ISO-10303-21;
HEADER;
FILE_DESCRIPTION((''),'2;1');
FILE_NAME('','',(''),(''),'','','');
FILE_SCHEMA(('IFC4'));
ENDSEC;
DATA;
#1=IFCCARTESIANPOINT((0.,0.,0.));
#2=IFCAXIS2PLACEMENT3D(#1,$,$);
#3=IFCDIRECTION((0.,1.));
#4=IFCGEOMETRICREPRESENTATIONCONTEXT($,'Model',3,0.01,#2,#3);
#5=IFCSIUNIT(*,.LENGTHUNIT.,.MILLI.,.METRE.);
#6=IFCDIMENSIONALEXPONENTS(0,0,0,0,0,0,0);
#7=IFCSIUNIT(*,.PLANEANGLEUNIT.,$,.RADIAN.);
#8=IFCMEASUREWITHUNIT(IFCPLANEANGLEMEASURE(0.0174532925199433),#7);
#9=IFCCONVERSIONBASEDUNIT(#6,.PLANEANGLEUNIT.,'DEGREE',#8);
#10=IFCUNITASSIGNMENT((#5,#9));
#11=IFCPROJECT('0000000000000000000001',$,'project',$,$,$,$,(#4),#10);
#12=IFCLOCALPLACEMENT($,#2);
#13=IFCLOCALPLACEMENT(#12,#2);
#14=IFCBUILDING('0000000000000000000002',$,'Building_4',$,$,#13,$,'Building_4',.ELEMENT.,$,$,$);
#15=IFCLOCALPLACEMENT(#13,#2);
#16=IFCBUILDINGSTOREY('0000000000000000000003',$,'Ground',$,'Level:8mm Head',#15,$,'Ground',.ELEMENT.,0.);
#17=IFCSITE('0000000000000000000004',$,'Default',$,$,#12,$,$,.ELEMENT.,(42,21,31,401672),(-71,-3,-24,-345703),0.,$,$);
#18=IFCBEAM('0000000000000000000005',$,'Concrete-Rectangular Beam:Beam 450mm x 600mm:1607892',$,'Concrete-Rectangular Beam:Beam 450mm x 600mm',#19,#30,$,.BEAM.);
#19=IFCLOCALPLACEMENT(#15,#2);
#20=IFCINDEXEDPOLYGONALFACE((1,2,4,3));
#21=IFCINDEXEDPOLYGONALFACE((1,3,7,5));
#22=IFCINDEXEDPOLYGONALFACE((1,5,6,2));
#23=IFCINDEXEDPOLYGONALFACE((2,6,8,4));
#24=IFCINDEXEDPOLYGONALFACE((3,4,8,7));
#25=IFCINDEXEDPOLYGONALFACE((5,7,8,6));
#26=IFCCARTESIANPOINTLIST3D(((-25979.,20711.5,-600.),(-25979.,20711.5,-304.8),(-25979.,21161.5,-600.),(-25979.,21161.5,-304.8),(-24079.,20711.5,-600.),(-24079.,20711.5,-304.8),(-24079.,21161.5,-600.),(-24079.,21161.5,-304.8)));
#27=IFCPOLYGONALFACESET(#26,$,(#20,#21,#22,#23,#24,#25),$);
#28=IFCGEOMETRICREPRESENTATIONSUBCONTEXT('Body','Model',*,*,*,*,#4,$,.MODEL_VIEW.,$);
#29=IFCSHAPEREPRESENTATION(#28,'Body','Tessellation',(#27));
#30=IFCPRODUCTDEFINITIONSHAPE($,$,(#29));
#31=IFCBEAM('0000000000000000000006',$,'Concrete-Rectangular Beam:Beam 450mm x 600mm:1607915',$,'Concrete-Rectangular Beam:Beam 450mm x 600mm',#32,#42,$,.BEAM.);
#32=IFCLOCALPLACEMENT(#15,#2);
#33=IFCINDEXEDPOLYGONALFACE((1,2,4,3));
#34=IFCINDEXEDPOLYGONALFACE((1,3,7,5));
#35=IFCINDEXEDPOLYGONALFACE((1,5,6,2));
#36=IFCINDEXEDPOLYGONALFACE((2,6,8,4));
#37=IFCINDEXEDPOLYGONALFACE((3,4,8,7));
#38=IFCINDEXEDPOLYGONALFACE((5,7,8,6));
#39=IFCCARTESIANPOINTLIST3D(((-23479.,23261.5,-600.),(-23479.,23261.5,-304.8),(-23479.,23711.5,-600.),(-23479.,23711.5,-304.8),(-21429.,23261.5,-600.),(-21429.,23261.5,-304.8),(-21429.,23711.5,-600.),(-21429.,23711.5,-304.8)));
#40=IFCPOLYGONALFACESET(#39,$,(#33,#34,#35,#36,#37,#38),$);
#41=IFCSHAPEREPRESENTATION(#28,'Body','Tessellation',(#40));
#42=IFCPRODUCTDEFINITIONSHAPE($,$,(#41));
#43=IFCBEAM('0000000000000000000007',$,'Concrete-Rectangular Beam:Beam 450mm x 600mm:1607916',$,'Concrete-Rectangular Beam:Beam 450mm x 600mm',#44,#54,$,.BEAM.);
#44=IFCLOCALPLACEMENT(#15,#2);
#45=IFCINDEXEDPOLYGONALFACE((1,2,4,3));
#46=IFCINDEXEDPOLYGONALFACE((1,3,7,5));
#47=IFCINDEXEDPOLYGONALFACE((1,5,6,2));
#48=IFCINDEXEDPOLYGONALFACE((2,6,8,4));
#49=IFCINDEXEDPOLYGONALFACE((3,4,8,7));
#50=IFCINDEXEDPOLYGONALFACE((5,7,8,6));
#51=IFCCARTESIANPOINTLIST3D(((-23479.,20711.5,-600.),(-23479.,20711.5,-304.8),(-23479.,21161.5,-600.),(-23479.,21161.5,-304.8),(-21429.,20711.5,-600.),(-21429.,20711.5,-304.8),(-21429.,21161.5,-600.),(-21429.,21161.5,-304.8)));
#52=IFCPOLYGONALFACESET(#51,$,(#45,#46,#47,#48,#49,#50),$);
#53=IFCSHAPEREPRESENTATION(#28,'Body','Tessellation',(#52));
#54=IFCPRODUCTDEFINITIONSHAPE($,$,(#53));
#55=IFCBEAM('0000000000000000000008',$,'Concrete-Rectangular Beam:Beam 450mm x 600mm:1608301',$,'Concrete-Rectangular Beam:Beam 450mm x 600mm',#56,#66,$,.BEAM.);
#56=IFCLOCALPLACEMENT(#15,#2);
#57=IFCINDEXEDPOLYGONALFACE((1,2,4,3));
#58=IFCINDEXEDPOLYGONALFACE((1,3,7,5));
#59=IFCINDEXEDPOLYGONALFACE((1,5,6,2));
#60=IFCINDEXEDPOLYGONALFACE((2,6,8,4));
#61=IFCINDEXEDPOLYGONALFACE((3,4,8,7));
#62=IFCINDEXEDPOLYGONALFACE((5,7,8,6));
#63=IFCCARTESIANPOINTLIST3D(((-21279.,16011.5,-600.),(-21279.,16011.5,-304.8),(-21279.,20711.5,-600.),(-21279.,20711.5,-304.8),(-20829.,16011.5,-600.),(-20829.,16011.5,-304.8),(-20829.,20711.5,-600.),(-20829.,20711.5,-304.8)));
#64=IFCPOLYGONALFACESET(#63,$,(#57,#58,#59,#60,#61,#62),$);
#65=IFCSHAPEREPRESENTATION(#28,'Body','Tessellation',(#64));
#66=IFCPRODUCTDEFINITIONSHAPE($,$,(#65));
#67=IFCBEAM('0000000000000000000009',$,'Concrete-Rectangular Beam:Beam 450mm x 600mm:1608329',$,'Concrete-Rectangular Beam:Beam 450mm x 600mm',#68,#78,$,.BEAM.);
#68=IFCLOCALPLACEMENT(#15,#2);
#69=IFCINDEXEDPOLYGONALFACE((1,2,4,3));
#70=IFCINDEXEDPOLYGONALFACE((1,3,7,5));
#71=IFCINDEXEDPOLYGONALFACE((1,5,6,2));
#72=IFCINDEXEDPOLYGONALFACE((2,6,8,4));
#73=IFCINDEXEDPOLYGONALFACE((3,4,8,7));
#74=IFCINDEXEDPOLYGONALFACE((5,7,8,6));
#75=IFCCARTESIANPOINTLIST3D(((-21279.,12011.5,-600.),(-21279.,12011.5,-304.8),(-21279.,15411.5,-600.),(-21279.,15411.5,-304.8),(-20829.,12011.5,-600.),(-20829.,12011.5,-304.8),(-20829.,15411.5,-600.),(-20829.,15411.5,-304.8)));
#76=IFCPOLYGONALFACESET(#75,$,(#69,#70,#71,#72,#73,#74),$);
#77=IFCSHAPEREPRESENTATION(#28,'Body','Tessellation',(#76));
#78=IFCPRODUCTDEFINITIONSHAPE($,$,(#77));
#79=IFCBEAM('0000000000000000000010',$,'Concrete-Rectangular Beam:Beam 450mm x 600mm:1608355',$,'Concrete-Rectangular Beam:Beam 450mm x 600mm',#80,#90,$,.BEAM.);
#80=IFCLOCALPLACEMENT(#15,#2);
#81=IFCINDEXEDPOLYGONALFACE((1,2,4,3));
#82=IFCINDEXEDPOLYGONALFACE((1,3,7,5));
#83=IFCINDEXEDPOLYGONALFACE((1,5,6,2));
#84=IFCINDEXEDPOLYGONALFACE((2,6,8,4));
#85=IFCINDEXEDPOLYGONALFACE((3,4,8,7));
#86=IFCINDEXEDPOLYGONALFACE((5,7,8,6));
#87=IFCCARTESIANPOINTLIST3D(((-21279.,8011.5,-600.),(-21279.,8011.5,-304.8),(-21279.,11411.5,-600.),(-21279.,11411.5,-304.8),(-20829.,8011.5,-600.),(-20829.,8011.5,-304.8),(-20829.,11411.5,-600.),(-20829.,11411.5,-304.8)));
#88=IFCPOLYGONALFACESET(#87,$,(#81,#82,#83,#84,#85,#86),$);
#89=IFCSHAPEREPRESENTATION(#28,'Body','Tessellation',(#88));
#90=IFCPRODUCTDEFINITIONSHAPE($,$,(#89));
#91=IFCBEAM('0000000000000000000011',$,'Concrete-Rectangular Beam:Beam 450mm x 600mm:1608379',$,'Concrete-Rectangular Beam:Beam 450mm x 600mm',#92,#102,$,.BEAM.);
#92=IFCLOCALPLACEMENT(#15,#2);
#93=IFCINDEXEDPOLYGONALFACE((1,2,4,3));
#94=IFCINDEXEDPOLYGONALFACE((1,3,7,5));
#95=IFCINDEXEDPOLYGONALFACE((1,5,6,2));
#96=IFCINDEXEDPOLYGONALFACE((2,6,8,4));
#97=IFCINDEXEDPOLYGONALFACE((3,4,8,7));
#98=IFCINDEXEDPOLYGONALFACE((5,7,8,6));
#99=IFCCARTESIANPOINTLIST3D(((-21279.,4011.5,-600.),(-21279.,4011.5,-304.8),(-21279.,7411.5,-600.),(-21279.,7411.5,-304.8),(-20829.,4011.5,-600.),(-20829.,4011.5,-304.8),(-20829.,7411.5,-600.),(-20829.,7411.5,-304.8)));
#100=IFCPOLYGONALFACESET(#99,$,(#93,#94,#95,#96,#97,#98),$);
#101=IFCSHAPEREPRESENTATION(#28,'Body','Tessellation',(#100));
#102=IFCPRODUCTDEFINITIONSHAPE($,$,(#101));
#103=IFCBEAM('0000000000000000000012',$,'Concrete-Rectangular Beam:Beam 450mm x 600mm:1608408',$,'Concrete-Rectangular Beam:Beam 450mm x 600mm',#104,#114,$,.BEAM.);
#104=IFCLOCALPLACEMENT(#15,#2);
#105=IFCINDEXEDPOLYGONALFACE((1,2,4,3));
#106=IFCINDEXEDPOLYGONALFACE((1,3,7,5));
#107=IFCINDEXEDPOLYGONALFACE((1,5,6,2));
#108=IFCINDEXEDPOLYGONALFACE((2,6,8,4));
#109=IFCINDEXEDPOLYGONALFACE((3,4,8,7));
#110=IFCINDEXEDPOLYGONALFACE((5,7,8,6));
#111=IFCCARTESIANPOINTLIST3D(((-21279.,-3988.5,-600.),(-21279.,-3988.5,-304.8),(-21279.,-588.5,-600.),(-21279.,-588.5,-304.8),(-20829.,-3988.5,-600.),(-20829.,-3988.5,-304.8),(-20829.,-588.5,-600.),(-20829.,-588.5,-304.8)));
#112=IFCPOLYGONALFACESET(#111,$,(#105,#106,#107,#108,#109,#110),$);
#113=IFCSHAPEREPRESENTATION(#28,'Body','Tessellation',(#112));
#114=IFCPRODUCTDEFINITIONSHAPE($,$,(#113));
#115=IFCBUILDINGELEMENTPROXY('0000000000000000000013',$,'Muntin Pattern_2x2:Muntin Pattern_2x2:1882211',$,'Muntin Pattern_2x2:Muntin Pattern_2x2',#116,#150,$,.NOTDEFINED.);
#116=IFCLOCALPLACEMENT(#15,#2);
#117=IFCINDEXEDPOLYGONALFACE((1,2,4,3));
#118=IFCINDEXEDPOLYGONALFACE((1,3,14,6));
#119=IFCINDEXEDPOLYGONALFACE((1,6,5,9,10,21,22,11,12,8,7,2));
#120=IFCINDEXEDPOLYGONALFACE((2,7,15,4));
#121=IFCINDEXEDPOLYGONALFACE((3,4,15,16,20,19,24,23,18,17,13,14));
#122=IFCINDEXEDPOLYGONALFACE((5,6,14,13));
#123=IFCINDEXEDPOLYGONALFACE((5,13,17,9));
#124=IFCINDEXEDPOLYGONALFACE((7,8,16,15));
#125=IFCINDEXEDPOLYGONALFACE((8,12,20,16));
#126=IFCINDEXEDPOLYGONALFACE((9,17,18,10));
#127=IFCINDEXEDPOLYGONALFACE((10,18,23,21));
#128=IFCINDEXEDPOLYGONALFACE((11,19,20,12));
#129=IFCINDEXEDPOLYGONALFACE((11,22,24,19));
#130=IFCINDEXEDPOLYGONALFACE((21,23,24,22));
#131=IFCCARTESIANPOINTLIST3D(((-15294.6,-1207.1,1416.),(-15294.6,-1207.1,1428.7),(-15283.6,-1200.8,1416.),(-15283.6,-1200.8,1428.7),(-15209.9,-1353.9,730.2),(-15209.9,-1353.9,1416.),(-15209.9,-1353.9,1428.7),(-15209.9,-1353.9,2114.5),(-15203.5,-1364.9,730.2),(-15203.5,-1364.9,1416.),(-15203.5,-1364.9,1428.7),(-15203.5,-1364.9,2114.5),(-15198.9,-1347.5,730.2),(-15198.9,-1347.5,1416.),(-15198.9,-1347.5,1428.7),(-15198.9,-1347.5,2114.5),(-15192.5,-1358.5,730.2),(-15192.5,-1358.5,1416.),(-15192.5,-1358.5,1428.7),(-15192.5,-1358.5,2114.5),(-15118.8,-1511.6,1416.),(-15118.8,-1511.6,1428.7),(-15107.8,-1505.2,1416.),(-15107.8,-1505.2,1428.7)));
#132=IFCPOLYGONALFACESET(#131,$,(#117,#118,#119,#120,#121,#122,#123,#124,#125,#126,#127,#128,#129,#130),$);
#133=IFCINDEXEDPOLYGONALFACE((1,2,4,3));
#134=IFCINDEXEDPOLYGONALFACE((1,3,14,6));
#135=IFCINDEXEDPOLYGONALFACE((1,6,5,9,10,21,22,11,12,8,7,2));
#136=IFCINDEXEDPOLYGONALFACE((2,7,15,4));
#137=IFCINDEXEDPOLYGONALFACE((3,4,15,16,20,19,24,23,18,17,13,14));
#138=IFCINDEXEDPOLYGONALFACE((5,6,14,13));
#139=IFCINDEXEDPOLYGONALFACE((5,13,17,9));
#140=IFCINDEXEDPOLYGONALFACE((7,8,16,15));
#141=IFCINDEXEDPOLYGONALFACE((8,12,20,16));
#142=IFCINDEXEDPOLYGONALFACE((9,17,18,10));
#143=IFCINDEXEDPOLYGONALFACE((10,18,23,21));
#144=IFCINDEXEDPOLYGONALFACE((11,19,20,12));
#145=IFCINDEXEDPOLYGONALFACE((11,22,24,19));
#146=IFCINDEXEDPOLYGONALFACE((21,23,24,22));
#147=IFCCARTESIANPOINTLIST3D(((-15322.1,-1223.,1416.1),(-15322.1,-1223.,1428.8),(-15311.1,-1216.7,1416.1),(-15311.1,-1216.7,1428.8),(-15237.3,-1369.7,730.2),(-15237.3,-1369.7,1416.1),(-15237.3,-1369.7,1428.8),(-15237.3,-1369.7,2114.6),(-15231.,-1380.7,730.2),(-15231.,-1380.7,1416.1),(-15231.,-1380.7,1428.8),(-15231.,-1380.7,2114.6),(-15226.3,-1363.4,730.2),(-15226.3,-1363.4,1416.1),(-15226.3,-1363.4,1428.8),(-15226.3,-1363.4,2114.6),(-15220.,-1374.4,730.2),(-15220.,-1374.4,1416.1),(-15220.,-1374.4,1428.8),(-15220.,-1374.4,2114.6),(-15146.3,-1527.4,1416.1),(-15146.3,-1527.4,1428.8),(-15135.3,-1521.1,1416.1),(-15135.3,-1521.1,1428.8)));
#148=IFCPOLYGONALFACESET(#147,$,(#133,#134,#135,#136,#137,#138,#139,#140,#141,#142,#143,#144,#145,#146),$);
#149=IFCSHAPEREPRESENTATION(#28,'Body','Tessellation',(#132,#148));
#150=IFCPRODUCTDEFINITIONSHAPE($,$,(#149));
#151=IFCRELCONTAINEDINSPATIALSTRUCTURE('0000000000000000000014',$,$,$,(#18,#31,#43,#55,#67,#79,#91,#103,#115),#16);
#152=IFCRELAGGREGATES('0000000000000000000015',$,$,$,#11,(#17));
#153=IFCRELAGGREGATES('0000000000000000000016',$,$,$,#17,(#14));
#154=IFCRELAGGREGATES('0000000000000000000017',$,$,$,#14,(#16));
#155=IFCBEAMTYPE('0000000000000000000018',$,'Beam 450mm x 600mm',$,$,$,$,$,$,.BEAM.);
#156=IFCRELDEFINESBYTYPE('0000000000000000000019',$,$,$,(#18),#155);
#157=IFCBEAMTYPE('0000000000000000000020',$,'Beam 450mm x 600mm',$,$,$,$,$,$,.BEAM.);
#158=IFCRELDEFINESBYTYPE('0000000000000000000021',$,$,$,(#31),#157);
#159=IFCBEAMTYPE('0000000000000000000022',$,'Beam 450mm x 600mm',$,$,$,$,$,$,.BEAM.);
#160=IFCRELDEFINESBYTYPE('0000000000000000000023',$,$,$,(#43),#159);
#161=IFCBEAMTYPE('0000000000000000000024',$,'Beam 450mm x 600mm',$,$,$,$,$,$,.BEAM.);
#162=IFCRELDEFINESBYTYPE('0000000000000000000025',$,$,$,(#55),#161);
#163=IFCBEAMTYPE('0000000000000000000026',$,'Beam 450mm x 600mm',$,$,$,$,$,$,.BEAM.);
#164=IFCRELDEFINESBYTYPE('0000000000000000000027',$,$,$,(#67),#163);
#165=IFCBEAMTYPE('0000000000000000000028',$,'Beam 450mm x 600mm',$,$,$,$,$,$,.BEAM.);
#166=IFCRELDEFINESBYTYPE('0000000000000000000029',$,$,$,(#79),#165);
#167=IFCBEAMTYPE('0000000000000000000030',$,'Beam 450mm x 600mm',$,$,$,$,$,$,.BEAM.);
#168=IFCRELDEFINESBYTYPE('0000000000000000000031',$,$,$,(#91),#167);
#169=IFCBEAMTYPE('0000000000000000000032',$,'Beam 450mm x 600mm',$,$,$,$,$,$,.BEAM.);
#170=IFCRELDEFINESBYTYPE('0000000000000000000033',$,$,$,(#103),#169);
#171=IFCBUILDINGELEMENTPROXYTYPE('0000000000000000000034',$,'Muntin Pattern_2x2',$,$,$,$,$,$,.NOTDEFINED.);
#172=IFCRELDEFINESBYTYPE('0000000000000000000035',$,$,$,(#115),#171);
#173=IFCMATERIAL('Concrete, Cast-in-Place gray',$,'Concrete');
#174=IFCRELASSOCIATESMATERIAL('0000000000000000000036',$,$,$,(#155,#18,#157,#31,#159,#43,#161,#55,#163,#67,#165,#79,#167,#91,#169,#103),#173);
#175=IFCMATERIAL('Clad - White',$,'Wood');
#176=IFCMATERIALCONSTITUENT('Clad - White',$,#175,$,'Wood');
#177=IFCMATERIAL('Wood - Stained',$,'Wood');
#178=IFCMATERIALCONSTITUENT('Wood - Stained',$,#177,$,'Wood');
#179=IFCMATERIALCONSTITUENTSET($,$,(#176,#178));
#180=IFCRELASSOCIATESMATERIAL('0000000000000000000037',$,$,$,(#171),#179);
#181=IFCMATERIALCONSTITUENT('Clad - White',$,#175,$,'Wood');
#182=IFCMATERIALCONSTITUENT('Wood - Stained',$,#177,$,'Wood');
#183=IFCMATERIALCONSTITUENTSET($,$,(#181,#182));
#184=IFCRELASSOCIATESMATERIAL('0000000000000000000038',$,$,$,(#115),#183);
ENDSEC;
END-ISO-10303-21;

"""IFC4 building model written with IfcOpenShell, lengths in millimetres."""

from ifc_helpers import new_model, entity, si_unit, converted_unit, direction, frame, origin, place, context, subcontext, project, spatial, indexed_curve, outline, extrude, source, transform, mapped, material, constituent, constituent_set, type_object, type_shapes, element, save


model = new_model("IFC4")

# Units and contexts
model_context = context("Model", 3, precision=0.01, world=origin(), true_north=direction((0.0, 1.0)))
body_context = subcontext(model_context, "Body", "Model", "MODEL_VIEW")
ifc_project = project(units=[si_unit("LENGTHUNIT", "METRE", prefix="MILLI"), converted_unit("PLANEANGLEUNIT", "DEGREE", entity("IfcPlaneAngleMeasure", 0.0174532925199433), si_unit("PLANEANGLEUNIT", "RADIAN"), dimensions=[0, 0, 0, 0, 0, 0, 0])], contexts=[model_context])

# Site, building, storey
site_placement = place(None, origin())
site = spatial("IfcSite", under=ifc_project, at=site_placement, Name="Default", CompositionType="ELEMENT", RefLatitude=(42, 21, 31, 401672), RefLongitude=(-71, -3, -24, -345703), RefElevation=0.0)
building_placement = place(site_placement, origin())
building = spatial("IfcBuilding", under=site, at=building_placement, Name="Building_4", LongName="Building_4", CompositionType="ELEMENT")
storey_placement = place(building_placement, origin())
storey = spatial("IfcBuildingStorey", under=building, at=storey_placement, Name="Ground", ObjectType="Level:8mm Head", LongName="Ground", CompositionType="ELEMENT", Elevation=0.0)

# Shared definitions
ifc_material_1 = material(Name="Concrete, Cast-in-Place gray", Category="Concrete")

# Beams
beam_type_1 = type_object("IfcBeamType", Name="Beam 450mm x 600mm", PredefinedType="BEAM", material=ifc_material_1)
shared_shape_1 = source(origin(), body_context, "Body", "SweptSolid", [
    extrude(outline(indexed_curve([(-147.6, -225.0), (147.6, -225.0), (147.6, 225.0), (-147.6, 225.0), (-147.6, -225.0)], self_intersect=False)), frame((-25979.0, 20936.5, -452.4), z_axis=(1.0, 0.0, 0.0), x_axis=(0.0, 0.0, -1.0)), (0.0, 0.0, 1.0), 1900.0),
])
type_shapes(beam_type_1, [shared_shape_1])
beam_1_placement = place(storey_placement, origin())
element("IfcBeam", 1, at=beam_1_placement, inside=storey, type_object=beam_type_1, material=ifc_material_1, Name="Concrete-Rectangular Beam:Beam 450mm x 600mm:1607892", ObjectType="Concrete-Rectangular Beam:Beam 450mm x 600mm", PredefinedType="BEAM", context=body_context, shape_type="MappedRepresentation", body=[
    mapped(shared_shape_1, transform((0.0, 0.0, 0.0), scale=1.0)),
])
beam_type_2 = type_object("IfcBeamType", Name="Beam 450mm x 600mm", PredefinedType="BEAM", material=ifc_material_1)
shared_shape_2 = source(origin(), body_context, "Body", "SweptSolid", [
    extrude(outline(indexed_curve([(-147.6, -225.0), (147.6, -225.0), (147.6, 225.0), (-147.6, 225.0), (-147.6, -225.0)], self_intersect=False)), frame((-23479.0, 23486.5, -452.4), z_axis=(1.0, 0.0, 0.0), x_axis=(0.0, 0.0, -1.0)), (0.0, 0.0, 1.0), 2050.0),
])
type_shapes(beam_type_2, [shared_shape_2])
beam_2_placement = place(storey_placement, origin())
element("IfcBeam", 2, at=beam_2_placement, inside=storey, type_object=beam_type_2, material=ifc_material_1, Name="Concrete-Rectangular Beam:Beam 450mm x 600mm:1607915", ObjectType="Concrete-Rectangular Beam:Beam 450mm x 600mm", PredefinedType="BEAM", context=body_context, shape_type="MappedRepresentation", body=[
    mapped(shared_shape_2, transform((0.0, 0.0, 0.0), scale=1.0)),
])
beam_type_3 = type_object("IfcBeamType", Name="Beam 450mm x 600mm", PredefinedType="BEAM", material=ifc_material_1)
shared_shape_3 = source(origin(), body_context, "Body", "SweptSolid", [
    extrude(outline(indexed_curve([(-147.6, -225.0), (147.6, -225.0), (147.6, 225.0), (-147.6, 225.0), (-147.6, -225.0)], self_intersect=False)), frame((-23479.0, 20936.5, -452.4), z_axis=(1.0, 0.0, 0.0), x_axis=(0.0, 0.0, -1.0)), (0.0, 0.0, 1.0), 2050.0),
])
type_shapes(beam_type_3, [shared_shape_3])
beam_3_placement = place(storey_placement, origin())
element("IfcBeam", 3, at=beam_3_placement, inside=storey, type_object=beam_type_3, material=ifc_material_1, Name="Concrete-Rectangular Beam:Beam 450mm x 600mm:1607916", ObjectType="Concrete-Rectangular Beam:Beam 450mm x 600mm", PredefinedType="BEAM", context=body_context, shape_type="MappedRepresentation", body=[
    mapped(shared_shape_3, transform((0.0, 0.0, 0.0), scale=1.0)),
])
beam_type_4 = type_object("IfcBeamType", Name="Beam 450mm x 600mm", PredefinedType="BEAM", material=ifc_material_1)
shared_shape_4 = source(origin(), body_context, "Body", "SweptSolid", [
    extrude(outline(indexed_curve([(-225.0, -147.6), (225.0, -147.6), (225.0, 147.6), (-225.0, 147.6), (-225.0, -147.6)], self_intersect=False)), frame((-21054.0, 16011.5, -452.4), z_axis=(0.0, 1.0, 0.0), x_axis=(-1.0, 0.0, 0.0)), (0.0, 0.0, 1.0), 4700.0),
])
type_shapes(beam_type_4, [shared_shape_4])
beam_4_placement = place(storey_placement, origin())
element("IfcBeam", 4, at=beam_4_placement, inside=storey, type_object=beam_type_4, material=ifc_material_1, Name="Concrete-Rectangular Beam:Beam 450mm x 600mm:1608301", ObjectType="Concrete-Rectangular Beam:Beam 450mm x 600mm", PredefinedType="BEAM", context=body_context, shape_type="MappedRepresentation", body=[
    mapped(shared_shape_4, transform((0.0, 0.0, 0.0), scale=1.0)),
])
beam_type_5 = type_object("IfcBeamType", Name="Beam 450mm x 600mm", PredefinedType="BEAM", material=ifc_material_1)
shared_shape_5 = source(origin(), body_context, "Body", "SweptSolid", [
    extrude(outline(indexed_curve([(-225.0, -147.6), (225.0, -147.6), (225.0, 147.6), (-225.0, 147.6), (-225.0, -147.6)], self_intersect=False)), frame((-21054.0, 12011.5, -452.4), z_axis=(0.0, 1.0, 0.0), x_axis=(-1.0, 0.0, 0.0)), (0.0, 0.0, 1.0), 3400.0),
])
type_shapes(beam_type_5, [shared_shape_5])
beam_5_placement = place(storey_placement, origin())
element("IfcBeam", 5, at=beam_5_placement, inside=storey, type_object=beam_type_5, material=ifc_material_1, Name="Concrete-Rectangular Beam:Beam 450mm x 600mm:1608329", ObjectType="Concrete-Rectangular Beam:Beam 450mm x 600mm", PredefinedType="BEAM", context=body_context, shape_type="MappedRepresentation", body=[
    mapped(shared_shape_5, transform((0.0, 0.0, 0.0), scale=1.0)),
])
beam_type_6 = type_object("IfcBeamType", Name="Beam 450mm x 600mm", PredefinedType="BEAM", material=ifc_material_1)
shared_shape_6 = source(origin(), body_context, "Body", "SweptSolid", [
    extrude(outline(indexed_curve([(-225.0, -147.6), (225.0, -147.6), (225.0, 147.6), (-225.0, 147.6), (-225.0, -147.6)], self_intersect=False)), frame((-21054.0, 8011.5, -452.4), z_axis=(0.0, 1.0, 0.0), x_axis=(-1.0, 0.0, 0.0)), (0.0, 0.0, 1.0), 3400.0),
])
type_shapes(beam_type_6, [shared_shape_6])
beam_6_placement = place(storey_placement, origin())
element("IfcBeam", 6, at=beam_6_placement, inside=storey, type_object=beam_type_6, material=ifc_material_1, Name="Concrete-Rectangular Beam:Beam 450mm x 600mm:1608355", ObjectType="Concrete-Rectangular Beam:Beam 450mm x 600mm", PredefinedType="BEAM", context=body_context, shape_type="MappedRepresentation", body=[
    mapped(shared_shape_6, transform((0.0, 0.0, 0.0), scale=1.0)),
])
beam_type_7 = type_object("IfcBeamType", Name="Beam 450mm x 600mm", PredefinedType="BEAM", material=ifc_material_1)
shared_shape_7 = source(origin(), body_context, "Body", "SweptSolid", [
    extrude(outline(indexed_curve([(-225.0, -147.6), (225.0, -147.6), (225.0, 147.6), (-225.0, 147.6), (-225.0, -147.6)], self_intersect=False)), frame((-21054.0, 4011.5, -452.4), z_axis=(0.0, 1.0, 0.0), x_axis=(-1.0, 0.0, 0.0)), (0.0, 0.0, 1.0), 3400.0),
])
type_shapes(beam_type_7, [shared_shape_7])
beam_7_placement = place(storey_placement, origin())
element("IfcBeam", 7, at=beam_7_placement, inside=storey, type_object=beam_type_7, material=ifc_material_1, Name="Concrete-Rectangular Beam:Beam 450mm x 600mm:1608379", ObjectType="Concrete-Rectangular Beam:Beam 450mm x 600mm", PredefinedType="BEAM", context=body_context, shape_type="MappedRepresentation", body=[
    mapped(shared_shape_7, transform((0.0, 0.0, 0.0), scale=1.0)),
])
beam_type_8 = type_object("IfcBeamType", Name="Beam 450mm x 600mm", PredefinedType="BEAM", material=ifc_material_1)
shared_shape_8 = source(origin(), body_context, "Body", "SweptSolid", [
    extrude(outline(indexed_curve([(-225.0, -147.6), (225.0, -147.6), (225.0, 147.6), (-225.0, 147.6), (-225.0, -147.6)], self_intersect=False)), frame((-21054.0, -588.5, -452.4), z_axis=(0.0, -1.0, 0.0), x_axis=(-1.0, 0.0, 0.0)), (0.0, 0.0, 1.0), 3400.0),
])
type_shapes(beam_type_8, [shared_shape_8])
beam_8_placement = place(storey_placement, origin())
element("IfcBeam", 8, at=beam_8_placement, inside=storey, type_object=beam_type_8, material=ifc_material_1, Name="Concrete-Rectangular Beam:Beam 450mm x 600mm:1608408", ObjectType="Concrete-Rectangular Beam:Beam 450mm x 600mm", PredefinedType="BEAM", context=body_context, shape_type="MappedRepresentation", body=[
    mapped(shared_shape_8, transform((0.0, 0.0, 0.0), scale=1.0)),
])

# Building element proxy
ifc_material_2 = material(Name="Clad - White", Category="Wood")
ifc_constituent_1 = constituent(ifc_material_2, Name="Clad - White", Category="Wood")
ifc_material_3 = material(Name="Wood - Stained", Category="Wood")
ifc_constituent_2 = constituent(ifc_material_3, Name="Wood - Stained", Category="Wood")
ifc_constituent_set_1 = constituent_set(constituents=[ifc_constituent_1, ifc_constituent_2])
ifc_constituent_3 = constituent(ifc_material_2, Name="Clad - White", Category="Wood")
ifc_constituent_4 = constituent(ifc_material_3, Name="Wood - Stained", Category="Wood")
ifc_constituent_set_2 = constituent_set(constituents=[ifc_constituent_3, ifc_constituent_4])
building_element_proxy_type_1 = type_object("IfcBuildingElementProxyType", Name="Muntin Pattern_2x2", PredefinedType="NOTDEFINED", material=ifc_constituent_set_2)
shared_shape_9 = source(origin(), body_context, "Body", "SweptSolid", [
    extrude(outline(indexed_curve([(6.4, -6.4), (692.1, -6.4), (692.1, 6.3), (6.4, 6.3), (6.4, 175.8), (-6.3, 175.8), (-6.3, 6.3), (-692.2, 6.3), (-692.2, -6.4), (-6.3, -6.4), (-6.3, -175.8), (6.4, -175.8), (6.4, -6.4)], self_intersect=False)), frame((0.0, 9.5, 692.1), z_axis=(0.0, 1.0, 0.0), x_axis=(0.0, 0.0, 1.0)), (0.0, 0.0, 1.0), 12.7),
    extrude(outline(indexed_curve([(6.4, -6.4), (692.1, -6.4), (692.1, 6.3), (6.4, 6.3), (6.4, 175.8), (-6.3, 175.8), (-6.3, 6.3), (-692.2, 6.3), (-692.2, -6.4), (-6.3, -6.4), (-6.3, -175.8), (6.4, -175.8), (6.4, -6.4)], self_intersect=False)), frame((0.0, -22.2, 692.2), z_axis=(0.0, 1.0, 0.0), x_axis=(0.0, 0.0, 1.0)), (0.0, 0.0, 1.0), 12.7),
])
type_shapes(building_element_proxy_type_1, [shared_shape_9])
proxy_1_placement = place(storey_placement, frame((-15214.9, -1364.1, 730.2), z_axis=(0.0, 0.0, 1.0), x_axis=(0.5, -0.866025, 0.0)))
element("IfcBuildingElementProxy", 9, at=proxy_1_placement, inside=storey, type_object=building_element_proxy_type_1, material=ifc_constituent_set_1, Name="Muntin Pattern_2x2:Muntin Pattern_2x2:1882211", ObjectType="Muntin Pattern_2x2:Muntin Pattern_2x2", PredefinedType="NOTDEFINED", context=body_context, shape_type="MappedRepresentation", body=[
    mapped(shared_shape_9, transform((0.0, 0.0, 0.0), scale=1.0)),
])

save(model, "model.ifc")
